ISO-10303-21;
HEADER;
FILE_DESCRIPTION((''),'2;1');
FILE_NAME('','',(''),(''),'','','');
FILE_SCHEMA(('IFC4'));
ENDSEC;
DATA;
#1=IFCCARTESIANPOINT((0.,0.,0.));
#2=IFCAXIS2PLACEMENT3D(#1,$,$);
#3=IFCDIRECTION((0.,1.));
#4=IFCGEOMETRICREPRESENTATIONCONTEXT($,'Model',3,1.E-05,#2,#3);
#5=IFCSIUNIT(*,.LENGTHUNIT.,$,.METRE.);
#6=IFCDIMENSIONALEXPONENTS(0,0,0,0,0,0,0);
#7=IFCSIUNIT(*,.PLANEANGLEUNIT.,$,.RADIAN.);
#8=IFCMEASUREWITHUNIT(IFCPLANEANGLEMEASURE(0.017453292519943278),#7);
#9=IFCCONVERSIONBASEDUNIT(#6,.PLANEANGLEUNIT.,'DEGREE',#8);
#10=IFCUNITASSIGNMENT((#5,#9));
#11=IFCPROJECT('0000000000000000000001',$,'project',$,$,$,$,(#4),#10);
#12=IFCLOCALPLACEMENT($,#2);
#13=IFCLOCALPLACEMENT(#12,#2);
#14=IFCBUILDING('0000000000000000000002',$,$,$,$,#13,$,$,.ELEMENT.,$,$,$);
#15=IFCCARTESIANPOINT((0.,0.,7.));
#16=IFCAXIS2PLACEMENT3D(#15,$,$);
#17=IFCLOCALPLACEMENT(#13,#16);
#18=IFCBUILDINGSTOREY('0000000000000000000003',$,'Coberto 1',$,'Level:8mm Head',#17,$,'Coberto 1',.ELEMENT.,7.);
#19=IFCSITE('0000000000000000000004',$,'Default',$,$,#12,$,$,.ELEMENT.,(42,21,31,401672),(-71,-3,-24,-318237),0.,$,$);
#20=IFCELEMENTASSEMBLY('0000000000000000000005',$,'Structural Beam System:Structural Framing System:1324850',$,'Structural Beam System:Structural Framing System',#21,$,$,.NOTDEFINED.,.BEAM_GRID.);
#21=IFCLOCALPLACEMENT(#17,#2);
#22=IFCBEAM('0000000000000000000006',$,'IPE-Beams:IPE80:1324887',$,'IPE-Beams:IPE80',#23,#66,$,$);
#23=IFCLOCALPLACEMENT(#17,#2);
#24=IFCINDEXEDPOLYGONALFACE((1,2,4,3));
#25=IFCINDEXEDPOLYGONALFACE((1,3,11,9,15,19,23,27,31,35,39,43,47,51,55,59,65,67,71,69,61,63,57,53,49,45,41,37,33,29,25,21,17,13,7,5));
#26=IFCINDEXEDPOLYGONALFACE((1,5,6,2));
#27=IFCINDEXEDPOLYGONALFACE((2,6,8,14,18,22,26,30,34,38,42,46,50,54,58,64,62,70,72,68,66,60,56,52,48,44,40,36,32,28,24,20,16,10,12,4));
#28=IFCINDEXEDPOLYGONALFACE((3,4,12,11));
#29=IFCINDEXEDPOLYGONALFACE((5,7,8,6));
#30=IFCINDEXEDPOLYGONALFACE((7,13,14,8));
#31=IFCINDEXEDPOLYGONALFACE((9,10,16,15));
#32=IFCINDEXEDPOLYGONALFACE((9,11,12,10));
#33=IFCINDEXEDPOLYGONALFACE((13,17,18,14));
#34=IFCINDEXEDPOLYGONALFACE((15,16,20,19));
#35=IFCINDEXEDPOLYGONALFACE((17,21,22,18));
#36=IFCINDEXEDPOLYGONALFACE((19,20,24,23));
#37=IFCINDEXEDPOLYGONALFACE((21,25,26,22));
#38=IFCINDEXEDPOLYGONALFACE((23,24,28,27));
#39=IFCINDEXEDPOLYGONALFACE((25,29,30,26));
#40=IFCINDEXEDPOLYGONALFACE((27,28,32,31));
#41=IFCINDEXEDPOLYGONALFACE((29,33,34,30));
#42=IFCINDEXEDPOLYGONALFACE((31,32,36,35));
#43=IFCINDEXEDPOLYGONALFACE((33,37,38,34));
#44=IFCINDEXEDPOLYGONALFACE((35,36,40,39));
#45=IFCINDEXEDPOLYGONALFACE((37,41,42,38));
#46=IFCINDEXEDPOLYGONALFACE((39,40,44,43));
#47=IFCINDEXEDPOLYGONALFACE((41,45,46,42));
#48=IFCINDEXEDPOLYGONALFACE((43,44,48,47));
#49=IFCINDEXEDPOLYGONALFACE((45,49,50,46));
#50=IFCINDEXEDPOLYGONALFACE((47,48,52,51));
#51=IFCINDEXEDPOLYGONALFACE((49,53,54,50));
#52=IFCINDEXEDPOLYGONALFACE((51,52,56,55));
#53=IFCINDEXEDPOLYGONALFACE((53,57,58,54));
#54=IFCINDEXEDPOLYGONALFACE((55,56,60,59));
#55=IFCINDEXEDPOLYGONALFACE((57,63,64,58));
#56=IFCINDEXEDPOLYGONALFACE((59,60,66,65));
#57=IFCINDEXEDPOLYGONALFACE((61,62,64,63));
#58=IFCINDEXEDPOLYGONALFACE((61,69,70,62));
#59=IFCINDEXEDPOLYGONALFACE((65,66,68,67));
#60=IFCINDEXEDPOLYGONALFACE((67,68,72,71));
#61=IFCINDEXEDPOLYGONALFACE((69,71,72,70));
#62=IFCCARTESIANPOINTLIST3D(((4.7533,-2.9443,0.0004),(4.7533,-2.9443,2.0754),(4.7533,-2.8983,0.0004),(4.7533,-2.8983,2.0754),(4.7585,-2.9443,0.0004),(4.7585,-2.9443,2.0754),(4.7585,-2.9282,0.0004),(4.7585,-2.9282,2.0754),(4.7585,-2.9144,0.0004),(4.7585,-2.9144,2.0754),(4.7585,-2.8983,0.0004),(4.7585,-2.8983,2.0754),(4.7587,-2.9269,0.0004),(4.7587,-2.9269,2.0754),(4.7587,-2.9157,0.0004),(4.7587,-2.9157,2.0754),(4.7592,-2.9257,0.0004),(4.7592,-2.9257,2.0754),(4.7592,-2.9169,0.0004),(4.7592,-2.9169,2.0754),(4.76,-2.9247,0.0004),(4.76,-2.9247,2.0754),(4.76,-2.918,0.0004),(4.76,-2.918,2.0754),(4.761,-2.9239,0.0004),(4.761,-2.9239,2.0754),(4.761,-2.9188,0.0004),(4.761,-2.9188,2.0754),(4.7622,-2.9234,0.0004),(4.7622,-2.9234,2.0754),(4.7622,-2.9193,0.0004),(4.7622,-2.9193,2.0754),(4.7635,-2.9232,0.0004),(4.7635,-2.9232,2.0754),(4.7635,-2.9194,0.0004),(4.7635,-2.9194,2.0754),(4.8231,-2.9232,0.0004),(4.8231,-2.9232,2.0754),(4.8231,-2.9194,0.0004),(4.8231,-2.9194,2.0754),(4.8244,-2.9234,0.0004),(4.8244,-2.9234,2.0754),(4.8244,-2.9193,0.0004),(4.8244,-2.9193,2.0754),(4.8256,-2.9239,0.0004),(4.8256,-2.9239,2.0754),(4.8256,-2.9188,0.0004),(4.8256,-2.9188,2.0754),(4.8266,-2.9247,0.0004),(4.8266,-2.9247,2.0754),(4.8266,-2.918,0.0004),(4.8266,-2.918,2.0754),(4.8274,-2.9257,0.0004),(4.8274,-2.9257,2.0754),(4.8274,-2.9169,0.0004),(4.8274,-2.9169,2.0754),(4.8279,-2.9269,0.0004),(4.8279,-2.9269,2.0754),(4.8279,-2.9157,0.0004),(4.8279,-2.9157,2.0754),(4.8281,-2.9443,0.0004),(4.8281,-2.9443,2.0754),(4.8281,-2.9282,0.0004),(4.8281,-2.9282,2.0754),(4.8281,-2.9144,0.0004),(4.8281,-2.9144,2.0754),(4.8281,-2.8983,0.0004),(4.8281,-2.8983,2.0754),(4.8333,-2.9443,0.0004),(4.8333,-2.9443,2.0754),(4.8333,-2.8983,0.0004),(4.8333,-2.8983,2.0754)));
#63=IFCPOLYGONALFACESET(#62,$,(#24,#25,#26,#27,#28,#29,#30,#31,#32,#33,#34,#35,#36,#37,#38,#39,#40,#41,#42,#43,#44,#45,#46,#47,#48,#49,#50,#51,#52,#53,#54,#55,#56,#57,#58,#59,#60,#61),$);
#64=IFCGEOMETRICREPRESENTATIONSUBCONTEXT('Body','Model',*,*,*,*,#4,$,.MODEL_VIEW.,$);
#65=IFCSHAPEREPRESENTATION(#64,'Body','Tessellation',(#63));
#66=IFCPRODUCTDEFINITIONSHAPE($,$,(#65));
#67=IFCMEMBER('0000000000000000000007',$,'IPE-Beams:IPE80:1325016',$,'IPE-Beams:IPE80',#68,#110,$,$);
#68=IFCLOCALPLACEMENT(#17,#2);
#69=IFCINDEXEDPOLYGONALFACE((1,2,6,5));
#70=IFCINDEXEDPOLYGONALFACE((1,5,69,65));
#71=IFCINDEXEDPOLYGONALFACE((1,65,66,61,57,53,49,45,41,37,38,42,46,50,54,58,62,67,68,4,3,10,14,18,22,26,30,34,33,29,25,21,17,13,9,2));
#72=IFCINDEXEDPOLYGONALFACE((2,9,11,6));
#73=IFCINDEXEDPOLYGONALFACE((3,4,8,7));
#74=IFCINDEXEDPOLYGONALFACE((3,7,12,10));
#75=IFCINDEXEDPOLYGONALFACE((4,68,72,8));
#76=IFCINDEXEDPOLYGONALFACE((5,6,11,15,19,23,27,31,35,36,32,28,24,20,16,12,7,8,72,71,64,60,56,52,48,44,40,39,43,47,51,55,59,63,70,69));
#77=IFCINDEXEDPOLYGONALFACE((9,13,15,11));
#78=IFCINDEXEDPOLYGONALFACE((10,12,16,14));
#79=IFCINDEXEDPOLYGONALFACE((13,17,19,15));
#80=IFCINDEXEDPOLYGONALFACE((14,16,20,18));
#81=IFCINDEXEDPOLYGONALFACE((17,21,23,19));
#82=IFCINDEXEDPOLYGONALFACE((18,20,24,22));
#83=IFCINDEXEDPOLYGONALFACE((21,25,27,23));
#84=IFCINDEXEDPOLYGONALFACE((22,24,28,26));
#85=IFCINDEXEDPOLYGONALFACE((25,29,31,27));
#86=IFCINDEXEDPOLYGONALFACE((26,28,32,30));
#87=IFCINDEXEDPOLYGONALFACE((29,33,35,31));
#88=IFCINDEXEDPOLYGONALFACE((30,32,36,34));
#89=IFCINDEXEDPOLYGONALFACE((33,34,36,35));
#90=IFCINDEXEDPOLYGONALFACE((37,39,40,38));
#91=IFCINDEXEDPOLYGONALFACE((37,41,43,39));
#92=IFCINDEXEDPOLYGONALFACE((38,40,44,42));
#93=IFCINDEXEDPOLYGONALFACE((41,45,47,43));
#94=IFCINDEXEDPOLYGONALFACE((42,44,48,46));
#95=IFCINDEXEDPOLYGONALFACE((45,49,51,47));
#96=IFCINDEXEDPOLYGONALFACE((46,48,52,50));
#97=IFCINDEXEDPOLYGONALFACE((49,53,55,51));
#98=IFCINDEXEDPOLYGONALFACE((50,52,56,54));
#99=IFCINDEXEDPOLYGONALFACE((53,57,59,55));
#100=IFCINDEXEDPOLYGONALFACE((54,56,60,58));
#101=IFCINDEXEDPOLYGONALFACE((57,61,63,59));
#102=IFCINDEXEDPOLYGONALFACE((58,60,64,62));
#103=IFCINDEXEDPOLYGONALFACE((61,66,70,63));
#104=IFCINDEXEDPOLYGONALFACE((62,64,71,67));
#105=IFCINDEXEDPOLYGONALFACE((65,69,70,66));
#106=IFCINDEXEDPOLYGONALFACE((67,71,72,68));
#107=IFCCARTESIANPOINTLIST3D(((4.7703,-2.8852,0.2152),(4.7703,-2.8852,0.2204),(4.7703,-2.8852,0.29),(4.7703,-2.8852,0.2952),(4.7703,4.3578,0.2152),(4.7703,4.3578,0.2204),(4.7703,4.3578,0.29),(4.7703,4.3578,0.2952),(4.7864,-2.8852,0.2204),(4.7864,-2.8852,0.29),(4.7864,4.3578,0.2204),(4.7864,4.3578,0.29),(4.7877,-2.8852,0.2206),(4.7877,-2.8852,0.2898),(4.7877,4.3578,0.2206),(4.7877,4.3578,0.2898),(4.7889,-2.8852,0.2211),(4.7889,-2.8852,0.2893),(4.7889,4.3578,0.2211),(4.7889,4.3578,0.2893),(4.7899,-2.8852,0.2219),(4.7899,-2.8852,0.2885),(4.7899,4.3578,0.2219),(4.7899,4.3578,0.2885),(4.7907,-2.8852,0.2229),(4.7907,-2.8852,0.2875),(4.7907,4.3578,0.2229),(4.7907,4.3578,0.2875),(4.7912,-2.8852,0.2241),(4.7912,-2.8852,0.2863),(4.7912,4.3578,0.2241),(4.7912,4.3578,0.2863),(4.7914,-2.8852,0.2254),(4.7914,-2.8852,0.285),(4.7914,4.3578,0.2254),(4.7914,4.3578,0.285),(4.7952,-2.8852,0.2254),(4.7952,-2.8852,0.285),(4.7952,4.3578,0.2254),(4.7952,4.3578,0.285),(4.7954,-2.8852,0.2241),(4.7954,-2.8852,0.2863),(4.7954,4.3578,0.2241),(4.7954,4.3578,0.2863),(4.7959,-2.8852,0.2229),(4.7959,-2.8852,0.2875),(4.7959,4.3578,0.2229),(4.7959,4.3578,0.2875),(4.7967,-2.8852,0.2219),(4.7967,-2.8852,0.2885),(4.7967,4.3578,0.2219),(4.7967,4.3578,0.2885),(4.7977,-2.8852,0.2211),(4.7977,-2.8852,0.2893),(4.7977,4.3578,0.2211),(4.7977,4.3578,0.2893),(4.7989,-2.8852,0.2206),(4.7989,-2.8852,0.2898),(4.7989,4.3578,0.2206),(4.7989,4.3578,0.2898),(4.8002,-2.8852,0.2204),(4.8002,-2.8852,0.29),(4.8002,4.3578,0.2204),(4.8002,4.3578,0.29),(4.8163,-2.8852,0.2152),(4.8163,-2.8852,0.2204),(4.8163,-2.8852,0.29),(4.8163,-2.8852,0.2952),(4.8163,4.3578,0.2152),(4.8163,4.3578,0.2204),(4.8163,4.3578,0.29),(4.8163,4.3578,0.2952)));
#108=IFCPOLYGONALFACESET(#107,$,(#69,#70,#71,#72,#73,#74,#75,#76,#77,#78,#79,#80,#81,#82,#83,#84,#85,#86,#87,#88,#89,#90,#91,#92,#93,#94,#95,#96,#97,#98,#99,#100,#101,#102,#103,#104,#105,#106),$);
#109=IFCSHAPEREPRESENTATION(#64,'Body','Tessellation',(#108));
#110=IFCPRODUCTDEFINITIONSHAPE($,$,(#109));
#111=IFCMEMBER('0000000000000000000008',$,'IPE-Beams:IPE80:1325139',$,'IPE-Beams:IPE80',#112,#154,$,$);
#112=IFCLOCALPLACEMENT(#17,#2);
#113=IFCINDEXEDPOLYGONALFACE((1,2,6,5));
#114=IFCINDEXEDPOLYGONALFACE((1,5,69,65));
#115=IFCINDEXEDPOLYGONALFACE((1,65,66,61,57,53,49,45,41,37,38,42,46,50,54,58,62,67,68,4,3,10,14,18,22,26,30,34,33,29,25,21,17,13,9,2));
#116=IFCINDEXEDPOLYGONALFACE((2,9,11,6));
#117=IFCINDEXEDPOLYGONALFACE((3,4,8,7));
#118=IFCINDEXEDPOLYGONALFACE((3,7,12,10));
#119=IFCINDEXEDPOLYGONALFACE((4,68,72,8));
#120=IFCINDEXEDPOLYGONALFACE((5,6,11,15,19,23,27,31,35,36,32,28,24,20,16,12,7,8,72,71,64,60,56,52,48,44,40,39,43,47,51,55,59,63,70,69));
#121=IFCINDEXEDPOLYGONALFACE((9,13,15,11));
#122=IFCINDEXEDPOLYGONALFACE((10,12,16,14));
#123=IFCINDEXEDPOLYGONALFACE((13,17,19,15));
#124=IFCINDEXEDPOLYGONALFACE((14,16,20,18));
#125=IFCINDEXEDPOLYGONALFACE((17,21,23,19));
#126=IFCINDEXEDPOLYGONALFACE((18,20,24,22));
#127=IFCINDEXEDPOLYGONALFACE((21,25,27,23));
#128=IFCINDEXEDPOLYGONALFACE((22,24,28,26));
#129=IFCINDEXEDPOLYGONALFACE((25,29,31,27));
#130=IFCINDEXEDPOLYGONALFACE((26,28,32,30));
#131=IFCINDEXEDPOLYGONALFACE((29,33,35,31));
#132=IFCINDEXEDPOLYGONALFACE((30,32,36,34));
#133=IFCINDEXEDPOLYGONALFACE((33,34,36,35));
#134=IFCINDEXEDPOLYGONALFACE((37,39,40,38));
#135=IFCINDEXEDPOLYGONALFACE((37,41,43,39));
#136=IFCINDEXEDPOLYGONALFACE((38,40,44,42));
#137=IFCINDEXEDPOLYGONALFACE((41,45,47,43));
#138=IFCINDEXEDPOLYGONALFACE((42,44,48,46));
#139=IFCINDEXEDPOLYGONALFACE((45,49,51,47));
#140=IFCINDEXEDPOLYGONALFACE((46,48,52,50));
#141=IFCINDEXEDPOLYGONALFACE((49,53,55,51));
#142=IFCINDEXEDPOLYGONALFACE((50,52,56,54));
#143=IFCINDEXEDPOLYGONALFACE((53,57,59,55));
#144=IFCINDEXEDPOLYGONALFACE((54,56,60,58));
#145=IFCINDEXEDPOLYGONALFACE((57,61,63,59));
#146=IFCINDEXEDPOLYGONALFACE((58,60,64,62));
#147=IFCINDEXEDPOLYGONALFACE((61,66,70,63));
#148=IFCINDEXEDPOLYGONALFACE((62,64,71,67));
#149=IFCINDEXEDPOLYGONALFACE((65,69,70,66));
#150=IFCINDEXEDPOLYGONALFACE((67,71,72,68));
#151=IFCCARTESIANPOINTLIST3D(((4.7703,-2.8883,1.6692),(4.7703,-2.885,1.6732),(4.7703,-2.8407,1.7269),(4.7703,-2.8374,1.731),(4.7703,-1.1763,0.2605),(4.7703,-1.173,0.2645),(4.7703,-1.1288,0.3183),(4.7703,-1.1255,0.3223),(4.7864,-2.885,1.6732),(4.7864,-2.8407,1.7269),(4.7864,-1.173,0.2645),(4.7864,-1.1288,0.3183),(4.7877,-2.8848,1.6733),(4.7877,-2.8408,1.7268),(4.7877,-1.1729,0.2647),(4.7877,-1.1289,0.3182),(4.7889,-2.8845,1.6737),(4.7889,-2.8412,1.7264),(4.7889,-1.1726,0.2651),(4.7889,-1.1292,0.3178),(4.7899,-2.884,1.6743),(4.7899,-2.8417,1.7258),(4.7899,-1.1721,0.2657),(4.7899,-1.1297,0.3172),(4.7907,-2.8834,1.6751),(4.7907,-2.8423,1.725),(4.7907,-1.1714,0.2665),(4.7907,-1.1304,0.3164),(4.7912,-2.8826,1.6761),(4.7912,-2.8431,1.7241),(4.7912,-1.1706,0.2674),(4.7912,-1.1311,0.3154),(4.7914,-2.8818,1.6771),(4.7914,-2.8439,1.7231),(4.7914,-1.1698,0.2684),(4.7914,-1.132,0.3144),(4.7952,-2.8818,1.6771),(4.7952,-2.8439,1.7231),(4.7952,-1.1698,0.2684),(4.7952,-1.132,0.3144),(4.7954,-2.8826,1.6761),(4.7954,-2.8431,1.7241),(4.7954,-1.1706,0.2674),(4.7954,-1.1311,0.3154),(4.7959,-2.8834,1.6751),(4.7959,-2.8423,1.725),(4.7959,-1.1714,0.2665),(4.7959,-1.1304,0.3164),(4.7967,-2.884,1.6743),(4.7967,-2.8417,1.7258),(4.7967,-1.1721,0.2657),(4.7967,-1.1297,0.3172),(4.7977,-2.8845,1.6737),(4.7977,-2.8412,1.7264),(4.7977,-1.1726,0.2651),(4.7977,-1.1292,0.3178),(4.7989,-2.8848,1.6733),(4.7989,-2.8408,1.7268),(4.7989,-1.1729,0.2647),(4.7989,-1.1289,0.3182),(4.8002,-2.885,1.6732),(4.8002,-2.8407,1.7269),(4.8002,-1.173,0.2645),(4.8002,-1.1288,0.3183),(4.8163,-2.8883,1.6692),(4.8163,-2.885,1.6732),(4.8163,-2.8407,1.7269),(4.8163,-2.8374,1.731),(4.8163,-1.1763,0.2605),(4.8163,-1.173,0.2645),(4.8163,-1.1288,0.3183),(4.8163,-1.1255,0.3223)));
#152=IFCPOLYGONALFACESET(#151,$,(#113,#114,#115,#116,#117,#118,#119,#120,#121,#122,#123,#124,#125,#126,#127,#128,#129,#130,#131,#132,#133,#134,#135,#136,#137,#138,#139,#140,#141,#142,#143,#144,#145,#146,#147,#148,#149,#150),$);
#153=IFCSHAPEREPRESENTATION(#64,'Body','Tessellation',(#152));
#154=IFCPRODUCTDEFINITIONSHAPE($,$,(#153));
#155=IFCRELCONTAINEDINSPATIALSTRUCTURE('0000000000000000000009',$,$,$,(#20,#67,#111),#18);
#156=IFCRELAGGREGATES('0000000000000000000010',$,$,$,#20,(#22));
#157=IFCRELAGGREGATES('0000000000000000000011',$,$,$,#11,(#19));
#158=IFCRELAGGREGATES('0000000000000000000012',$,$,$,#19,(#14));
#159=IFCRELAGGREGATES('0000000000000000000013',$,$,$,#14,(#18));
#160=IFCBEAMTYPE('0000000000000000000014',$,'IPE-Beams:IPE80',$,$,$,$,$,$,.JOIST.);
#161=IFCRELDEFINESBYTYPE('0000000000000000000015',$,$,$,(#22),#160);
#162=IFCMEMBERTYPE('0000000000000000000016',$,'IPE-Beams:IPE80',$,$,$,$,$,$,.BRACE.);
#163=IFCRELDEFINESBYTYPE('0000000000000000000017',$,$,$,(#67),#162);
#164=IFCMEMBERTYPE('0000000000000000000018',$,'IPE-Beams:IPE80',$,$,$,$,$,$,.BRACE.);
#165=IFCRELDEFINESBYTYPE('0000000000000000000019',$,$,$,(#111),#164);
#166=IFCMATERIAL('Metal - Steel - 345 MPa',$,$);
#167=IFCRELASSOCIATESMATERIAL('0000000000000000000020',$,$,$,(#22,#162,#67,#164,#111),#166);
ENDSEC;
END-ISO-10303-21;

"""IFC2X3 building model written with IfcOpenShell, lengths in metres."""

from ifc_helpers import new_model, entity, si_unit, converted_unit, direction, frame, frame_2d, origin, place, context, subcontext, project, spatial, polyline, circle_curve, parameter, trimmed, segment, composite_curve, outline, extrude, source, transform, mapped, material, type_object, type_shapes, element, aggregate, save


model = new_model("IFC2X3")

# Units and contexts
model_context = context("Model", 3, precision=1e-05, world=origin(), true_north=direction((0.0, 1.0)))
body_context = subcontext(model_context, "Body", "Model", "MODEL_VIEW")
ifc_project = project(units=[si_unit("LENGTHUNIT", "METRE"), converted_unit("PLANEANGLEUNIT", "DEGREE", entity("IfcPlaneAngleMeasure", 0.017453292519943278), si_unit("PLANEANGLEUNIT", "RADIAN"), dimensions=[0, 0, 0, 0, 0, 0, 0])], contexts=[model_context])

# Site, building, storey
site_placement = place(None, origin())
site = spatial("IfcSite", under=ifc_project, at=site_placement, Name="Default", CompositionType="ELEMENT", RefLatitude=(42, 21, 31, 401672), RefLongitude=(-71, -3, -24, -318237), RefElevation=0.0)
building_placement = place(site_placement, origin())
building = spatial("IfcBuilding", under=site, at=building_placement, CompositionType="ELEMENT")
storey_placement = place(building_placement, frame((0.0, 0.0, 7.0)))
storey = spatial("IfcBuildingStorey", under=building, at=storey_placement, Name="Coberto 1", ObjectType="Level:8mm Head", LongName="Coberto 1", CompositionType="ELEMENT", Elevation=7.0)

# Shared definitions
ifc_material_1 = material(Name="Metal - Steel - 345 MPa")

# Element assembly, beam
assembly_1_placement = place(storey_placement, origin())
assembly_1 = element("IfcElementAssembly", 1, at=assembly_1_placement, inside=storey, Name="Structural Beam System:Structural Framing System:1324850", ObjectType="Structural Beam System:Structural Framing System", AssemblyPlace="NOTDEFINED", PredefinedType="BEAM_GRID")
beam_type_1 = type_object("IfcBeamType", Name="IPE-Beams:IPE80", PredefinedType="JOIST")
beam_1_placement = place(assembly_1_placement, frame((4.7533, -2.9213, 2.0757), z_axis=(1.0, 0.0, 0.0), x_axis=(0.0, 0.0, -1.0)))
beam_1 = element("IfcBeam", 2, at=beam_1_placement, type_object=beam_type_1, material=ifc_material_1, Name="IPE-Beams:IPE80:1324887", ObjectType="IPE-Beams:IPE80", context=body_context, shape_type="SweptSolid", body=[
    extrude(outline(composite_curve([segment(polyline([(0.0348, -0.023), (0.04, -0.023)]), True, "CONTINUOUS"), segment(polyline([(0.04, -0.023), (0.04, 0.023)]), True, "CONTINUOUS"), segment(polyline([(0.04, 0.023), (0.0348, 0.023)]), True, "CONTINUOUS"), segment(polyline([(0.0348, 0.023), (0.0348, 0.0069)]), True, "CONTINUOUS"), segment(trimmed(circle_curve(frame_2d((0.0298, 0.0069), x_axis=(1.0, 0.0)), 0.005), [parameter(270.0)], [parameter(0.0)], True, "PARAMETER"), False, "CONTINUOUS"), segment(polyline([(0.0298, 0.0019), (-0.0298, 0.0019)]), True, "CONTINUOUS"), segment(trimmed(circle_curve(frame_2d((-0.0298, 0.0069), x_axis=(0.0, -1.0)), 0.005), [parameter(270.0)], [parameter(0.0)], True, "PARAMETER"), False, "CONTINUOUS"), segment(polyline([(-0.0348, 0.0069), (-0.0348, 0.023)]), True, "CONTINUOUS"), segment(polyline([(-0.0348, 0.023), (-0.04, 0.023)]), True, "CONTINUOUS"), segment(polyline([(-0.04, 0.023), (-0.04, -0.023)]), True, "CONTINUOUS"), segment(polyline([(-0.04, -0.023), (-0.0348, -0.023)]), True, "CONTINUOUS"), segment(polyline([(-0.0348, -0.023), (-0.0348, -0.0069)]), True, "CONTINUOUS"), segment(trimmed(circle_curve(frame_2d((-0.0298, -0.0069), x_axis=(-1.0, 0.0)), 0.005), [parameter(270.0)], [parameter(0.0)], True, "PARAMETER"), False, "CONTINUOUS"), segment(polyline([(-0.0298, -0.0019), (0.0298, -0.0019)]), True, "CONTINUOUS"), segment(trimmed(circle_curve(frame_2d((0.0298, -0.0069), x_axis=(0.0, 1.0)), 0.005), [parameter(270.0)], [parameter(0.0)], True, "PARAMETER"), False, "CONTINUOUS"), segment(polyline([(0.0348, -0.0069), (0.0348, -0.023)]), True, "CONTINUOUS")], self_intersect=False)), frame((0.0004, 0.0, 0.04), z_axis=(1.0, 0.0, 0.0), x_axis=(0.0, 0.0, -1.0)), (0.0, 0.0, 1.0), 2.075),
])
aggregate(assembly_1, [beam_1])

# Members
member_type_1 = type_object("IfcMemberType", Name="IPE-Beams:IPE80", PredefinedType="BRACE", material=ifc_material_1)
shared_shape_1 = source(origin(), body_context, "Body", "SweptSolid", [
    extrude(outline(composite_curve([segment(polyline([(-0.023, -0.0348), (-0.023, -0.04)]), True, "CONTINUOUS"), segment(polyline([(-0.023, -0.04), (0.023, -0.04)]), True, "CONTINUOUS"), segment(polyline([(0.023, -0.04), (0.023, -0.0348)]), True, "CONTINUOUS"), segment(polyline([(0.023, -0.0348), (0.0069, -0.0348)]), True, "CONTINUOUS"), segment(trimmed(circle_curve(frame_2d((0.0069, -0.0298), x_axis=(1.0, 0.0)), 0.005), [parameter(180.0)], [parameter(270.0)], True, "PARAMETER"), False, "CONTINUOUS"), segment(polyline([(0.0019, -0.0298), (0.0019, 0.0298)]), True, "CONTINUOUS"), segment(trimmed(circle_curve(frame_2d((0.0069, 0.0298), x_axis=(1.0, 0.0)), 0.005), [parameter(90.0)], [parameter(180.0)], True, "PARAMETER"), False, "CONTINUOUS"), segment(polyline([(0.0069, 0.0348), (0.023, 0.0348)]), True, "CONTINUOUS"), segment(polyline([(0.023, 0.0348), (0.023, 0.04)]), True, "CONTINUOUS"), segment(polyline([(0.023, 0.04), (-0.023, 0.04)]), True, "CONTINUOUS"), segment(polyline([(-0.023, 0.04), (-0.023, 0.0348)]), True, "CONTINUOUS"), segment(polyline([(-0.023, 0.0348), (-0.0069, 0.0348)]), True, "CONTINUOUS"), segment(trimmed(circle_curve(frame_2d((-0.0069, 0.0298), x_axis=(1.0, 0.0)), 0.005), [parameter(360.0)], [parameter(90.0)], True, "PARAMETER"), False, "CONTINUOUS"), segment(polyline([(-0.0019, 0.0298), (-0.0019, -0.0298)]), True, "CONTINUOUS"), segment(trimmed(circle_curve(frame_2d((-0.0069, -0.0298), x_axis=(1.0, 0.0)), 0.005), [parameter(270.0)], [parameter(0.0)], True, "PARAMETER"), False, "CONTINUOUS"), segment(polyline([(-0.0069, -0.0348), (-0.023, -0.0348)]), True, "CONTINUOUS")], self_intersect=False)), frame((-3.6215, 0.0, 0.0), z_axis=(-1.0, 0.0, 0.0), x_axis=(0.0, -1.0, 0.0)), (0.0, 0.0, -1.0), 7.243),
])
type_shapes(member_type_1, [shared_shape_1])
member_1_placement = place(storey_placement, frame((4.7933, 0.7363, 0.2552), z_axis=(0.0, 0.0, 1.0), x_axis=(0.0, 1.0, 0.0)))
element("IfcMember", 3, at=member_1_placement, inside=storey, type_object=member_type_1, material=ifc_material_1, Name="IPE-Beams:IPE80:1325016", ObjectType="IPE-Beams:IPE80", context=body_context, shape_type="MappedRepresentation", body=[
    mapped(shared_shape_1, transform((0.0, 0.0, 0.0), scale=1.0)),
])
member_type_2 = type_object("IfcMemberType", Name="IPE-Beams:IPE80", PredefinedType="BRACE", material=ifc_material_1)
shared_shape_2 = source(origin(), body_context, "Body", "SweptSolid", [
    extrude(outline(composite_curve([segment(polyline([(-0.023, -0.0348), (-0.023, -0.04)]), True, "CONTINUOUS"), segment(polyline([(-0.023, -0.04), (0.023, -0.04)]), True, "CONTINUOUS"), segment(polyline([(0.023, -0.04), (0.023, -0.0348)]), True, "CONTINUOUS"), segment(polyline([(0.023, -0.0348), (0.0069, -0.0348)]), True, "CONTINUOUS"), segment(trimmed(circle_curve(frame_2d((0.0069, -0.0298), x_axis=(1.0, 0.0)), 0.005), [parameter(180.0)], [parameter(270.0)], True, "PARAMETER"), False, "CONTINUOUS"), segment(polyline([(0.0019, -0.0298), (0.0019, 0.0298)]), True, "CONTINUOUS"), segment(trimmed(circle_curve(frame_2d((0.0069, 0.0298), x_axis=(1.0, 0.0)), 0.005), [parameter(90.0)], [parameter(180.0)], True, "PARAMETER"), False, "CONTINUOUS"), segment(polyline([(0.0069, 0.0348), (0.023, 0.0348)]), True, "CONTINUOUS"), segment(polyline([(0.023, 0.0348), (0.023, 0.04)]), True, "CONTINUOUS"), segment(polyline([(0.023, 0.04), (-0.023, 0.04)]), True, "CONTINUOUS"), segment(polyline([(-0.023, 0.04), (-0.023, 0.0348)]), True, "CONTINUOUS"), segment(polyline([(-0.023, 0.0348), (-0.0069, 0.0348)]), True, "CONTINUOUS"), segment(trimmed(circle_curve(frame_2d((-0.0069, 0.0298), x_axis=(1.0, 0.0)), 0.005), [parameter(360.0)], [parameter(90.0)], True, "PARAMETER"), False, "CONTINUOUS"), segment(polyline([(-0.0019, 0.0298), (-0.0019, -0.0298)]), True, "CONTINUOUS"), segment(trimmed(circle_curve(frame_2d((-0.0069, -0.0298), x_axis=(1.0, 0.0)), 0.005), [parameter(270.0)], [parameter(0.0)], True, "PARAMETER"), False, "CONTINUOUS"), segment(polyline([(-0.0069, -0.0348), (-0.023, -0.0348)]), True, "CONTINUOUS")], self_intersect=False)), frame((-1.0755, 0.0, 0.0), z_axis=(-1.0, 0.0, 0.0), x_axis=(0.0, -1.0, 0.0)), (0.0, 0.0, -1.0), 2.217),
])
type_shapes(member_type_2, [shared_shape_2])
member_2_placement = place(storey_placement, frame((4.7933, -2.0323, 1.0167), z_axis=(0.0, 0.635388, 0.772193), x_axis=(0.0, 0.772193, -0.635388)))
element("IfcMember", 4, at=member_2_placement, inside=storey, type_object=member_type_2, material=ifc_material_1, Name="IPE-Beams:IPE80:1325139", ObjectType="IPE-Beams:IPE80", context=body_context, shape_type="MappedRepresentation", body=[
    mapped(shared_shape_2, transform((0.0, 0.0, 0.0), scale=1.0)),
])

save(model, "model.ifc")
